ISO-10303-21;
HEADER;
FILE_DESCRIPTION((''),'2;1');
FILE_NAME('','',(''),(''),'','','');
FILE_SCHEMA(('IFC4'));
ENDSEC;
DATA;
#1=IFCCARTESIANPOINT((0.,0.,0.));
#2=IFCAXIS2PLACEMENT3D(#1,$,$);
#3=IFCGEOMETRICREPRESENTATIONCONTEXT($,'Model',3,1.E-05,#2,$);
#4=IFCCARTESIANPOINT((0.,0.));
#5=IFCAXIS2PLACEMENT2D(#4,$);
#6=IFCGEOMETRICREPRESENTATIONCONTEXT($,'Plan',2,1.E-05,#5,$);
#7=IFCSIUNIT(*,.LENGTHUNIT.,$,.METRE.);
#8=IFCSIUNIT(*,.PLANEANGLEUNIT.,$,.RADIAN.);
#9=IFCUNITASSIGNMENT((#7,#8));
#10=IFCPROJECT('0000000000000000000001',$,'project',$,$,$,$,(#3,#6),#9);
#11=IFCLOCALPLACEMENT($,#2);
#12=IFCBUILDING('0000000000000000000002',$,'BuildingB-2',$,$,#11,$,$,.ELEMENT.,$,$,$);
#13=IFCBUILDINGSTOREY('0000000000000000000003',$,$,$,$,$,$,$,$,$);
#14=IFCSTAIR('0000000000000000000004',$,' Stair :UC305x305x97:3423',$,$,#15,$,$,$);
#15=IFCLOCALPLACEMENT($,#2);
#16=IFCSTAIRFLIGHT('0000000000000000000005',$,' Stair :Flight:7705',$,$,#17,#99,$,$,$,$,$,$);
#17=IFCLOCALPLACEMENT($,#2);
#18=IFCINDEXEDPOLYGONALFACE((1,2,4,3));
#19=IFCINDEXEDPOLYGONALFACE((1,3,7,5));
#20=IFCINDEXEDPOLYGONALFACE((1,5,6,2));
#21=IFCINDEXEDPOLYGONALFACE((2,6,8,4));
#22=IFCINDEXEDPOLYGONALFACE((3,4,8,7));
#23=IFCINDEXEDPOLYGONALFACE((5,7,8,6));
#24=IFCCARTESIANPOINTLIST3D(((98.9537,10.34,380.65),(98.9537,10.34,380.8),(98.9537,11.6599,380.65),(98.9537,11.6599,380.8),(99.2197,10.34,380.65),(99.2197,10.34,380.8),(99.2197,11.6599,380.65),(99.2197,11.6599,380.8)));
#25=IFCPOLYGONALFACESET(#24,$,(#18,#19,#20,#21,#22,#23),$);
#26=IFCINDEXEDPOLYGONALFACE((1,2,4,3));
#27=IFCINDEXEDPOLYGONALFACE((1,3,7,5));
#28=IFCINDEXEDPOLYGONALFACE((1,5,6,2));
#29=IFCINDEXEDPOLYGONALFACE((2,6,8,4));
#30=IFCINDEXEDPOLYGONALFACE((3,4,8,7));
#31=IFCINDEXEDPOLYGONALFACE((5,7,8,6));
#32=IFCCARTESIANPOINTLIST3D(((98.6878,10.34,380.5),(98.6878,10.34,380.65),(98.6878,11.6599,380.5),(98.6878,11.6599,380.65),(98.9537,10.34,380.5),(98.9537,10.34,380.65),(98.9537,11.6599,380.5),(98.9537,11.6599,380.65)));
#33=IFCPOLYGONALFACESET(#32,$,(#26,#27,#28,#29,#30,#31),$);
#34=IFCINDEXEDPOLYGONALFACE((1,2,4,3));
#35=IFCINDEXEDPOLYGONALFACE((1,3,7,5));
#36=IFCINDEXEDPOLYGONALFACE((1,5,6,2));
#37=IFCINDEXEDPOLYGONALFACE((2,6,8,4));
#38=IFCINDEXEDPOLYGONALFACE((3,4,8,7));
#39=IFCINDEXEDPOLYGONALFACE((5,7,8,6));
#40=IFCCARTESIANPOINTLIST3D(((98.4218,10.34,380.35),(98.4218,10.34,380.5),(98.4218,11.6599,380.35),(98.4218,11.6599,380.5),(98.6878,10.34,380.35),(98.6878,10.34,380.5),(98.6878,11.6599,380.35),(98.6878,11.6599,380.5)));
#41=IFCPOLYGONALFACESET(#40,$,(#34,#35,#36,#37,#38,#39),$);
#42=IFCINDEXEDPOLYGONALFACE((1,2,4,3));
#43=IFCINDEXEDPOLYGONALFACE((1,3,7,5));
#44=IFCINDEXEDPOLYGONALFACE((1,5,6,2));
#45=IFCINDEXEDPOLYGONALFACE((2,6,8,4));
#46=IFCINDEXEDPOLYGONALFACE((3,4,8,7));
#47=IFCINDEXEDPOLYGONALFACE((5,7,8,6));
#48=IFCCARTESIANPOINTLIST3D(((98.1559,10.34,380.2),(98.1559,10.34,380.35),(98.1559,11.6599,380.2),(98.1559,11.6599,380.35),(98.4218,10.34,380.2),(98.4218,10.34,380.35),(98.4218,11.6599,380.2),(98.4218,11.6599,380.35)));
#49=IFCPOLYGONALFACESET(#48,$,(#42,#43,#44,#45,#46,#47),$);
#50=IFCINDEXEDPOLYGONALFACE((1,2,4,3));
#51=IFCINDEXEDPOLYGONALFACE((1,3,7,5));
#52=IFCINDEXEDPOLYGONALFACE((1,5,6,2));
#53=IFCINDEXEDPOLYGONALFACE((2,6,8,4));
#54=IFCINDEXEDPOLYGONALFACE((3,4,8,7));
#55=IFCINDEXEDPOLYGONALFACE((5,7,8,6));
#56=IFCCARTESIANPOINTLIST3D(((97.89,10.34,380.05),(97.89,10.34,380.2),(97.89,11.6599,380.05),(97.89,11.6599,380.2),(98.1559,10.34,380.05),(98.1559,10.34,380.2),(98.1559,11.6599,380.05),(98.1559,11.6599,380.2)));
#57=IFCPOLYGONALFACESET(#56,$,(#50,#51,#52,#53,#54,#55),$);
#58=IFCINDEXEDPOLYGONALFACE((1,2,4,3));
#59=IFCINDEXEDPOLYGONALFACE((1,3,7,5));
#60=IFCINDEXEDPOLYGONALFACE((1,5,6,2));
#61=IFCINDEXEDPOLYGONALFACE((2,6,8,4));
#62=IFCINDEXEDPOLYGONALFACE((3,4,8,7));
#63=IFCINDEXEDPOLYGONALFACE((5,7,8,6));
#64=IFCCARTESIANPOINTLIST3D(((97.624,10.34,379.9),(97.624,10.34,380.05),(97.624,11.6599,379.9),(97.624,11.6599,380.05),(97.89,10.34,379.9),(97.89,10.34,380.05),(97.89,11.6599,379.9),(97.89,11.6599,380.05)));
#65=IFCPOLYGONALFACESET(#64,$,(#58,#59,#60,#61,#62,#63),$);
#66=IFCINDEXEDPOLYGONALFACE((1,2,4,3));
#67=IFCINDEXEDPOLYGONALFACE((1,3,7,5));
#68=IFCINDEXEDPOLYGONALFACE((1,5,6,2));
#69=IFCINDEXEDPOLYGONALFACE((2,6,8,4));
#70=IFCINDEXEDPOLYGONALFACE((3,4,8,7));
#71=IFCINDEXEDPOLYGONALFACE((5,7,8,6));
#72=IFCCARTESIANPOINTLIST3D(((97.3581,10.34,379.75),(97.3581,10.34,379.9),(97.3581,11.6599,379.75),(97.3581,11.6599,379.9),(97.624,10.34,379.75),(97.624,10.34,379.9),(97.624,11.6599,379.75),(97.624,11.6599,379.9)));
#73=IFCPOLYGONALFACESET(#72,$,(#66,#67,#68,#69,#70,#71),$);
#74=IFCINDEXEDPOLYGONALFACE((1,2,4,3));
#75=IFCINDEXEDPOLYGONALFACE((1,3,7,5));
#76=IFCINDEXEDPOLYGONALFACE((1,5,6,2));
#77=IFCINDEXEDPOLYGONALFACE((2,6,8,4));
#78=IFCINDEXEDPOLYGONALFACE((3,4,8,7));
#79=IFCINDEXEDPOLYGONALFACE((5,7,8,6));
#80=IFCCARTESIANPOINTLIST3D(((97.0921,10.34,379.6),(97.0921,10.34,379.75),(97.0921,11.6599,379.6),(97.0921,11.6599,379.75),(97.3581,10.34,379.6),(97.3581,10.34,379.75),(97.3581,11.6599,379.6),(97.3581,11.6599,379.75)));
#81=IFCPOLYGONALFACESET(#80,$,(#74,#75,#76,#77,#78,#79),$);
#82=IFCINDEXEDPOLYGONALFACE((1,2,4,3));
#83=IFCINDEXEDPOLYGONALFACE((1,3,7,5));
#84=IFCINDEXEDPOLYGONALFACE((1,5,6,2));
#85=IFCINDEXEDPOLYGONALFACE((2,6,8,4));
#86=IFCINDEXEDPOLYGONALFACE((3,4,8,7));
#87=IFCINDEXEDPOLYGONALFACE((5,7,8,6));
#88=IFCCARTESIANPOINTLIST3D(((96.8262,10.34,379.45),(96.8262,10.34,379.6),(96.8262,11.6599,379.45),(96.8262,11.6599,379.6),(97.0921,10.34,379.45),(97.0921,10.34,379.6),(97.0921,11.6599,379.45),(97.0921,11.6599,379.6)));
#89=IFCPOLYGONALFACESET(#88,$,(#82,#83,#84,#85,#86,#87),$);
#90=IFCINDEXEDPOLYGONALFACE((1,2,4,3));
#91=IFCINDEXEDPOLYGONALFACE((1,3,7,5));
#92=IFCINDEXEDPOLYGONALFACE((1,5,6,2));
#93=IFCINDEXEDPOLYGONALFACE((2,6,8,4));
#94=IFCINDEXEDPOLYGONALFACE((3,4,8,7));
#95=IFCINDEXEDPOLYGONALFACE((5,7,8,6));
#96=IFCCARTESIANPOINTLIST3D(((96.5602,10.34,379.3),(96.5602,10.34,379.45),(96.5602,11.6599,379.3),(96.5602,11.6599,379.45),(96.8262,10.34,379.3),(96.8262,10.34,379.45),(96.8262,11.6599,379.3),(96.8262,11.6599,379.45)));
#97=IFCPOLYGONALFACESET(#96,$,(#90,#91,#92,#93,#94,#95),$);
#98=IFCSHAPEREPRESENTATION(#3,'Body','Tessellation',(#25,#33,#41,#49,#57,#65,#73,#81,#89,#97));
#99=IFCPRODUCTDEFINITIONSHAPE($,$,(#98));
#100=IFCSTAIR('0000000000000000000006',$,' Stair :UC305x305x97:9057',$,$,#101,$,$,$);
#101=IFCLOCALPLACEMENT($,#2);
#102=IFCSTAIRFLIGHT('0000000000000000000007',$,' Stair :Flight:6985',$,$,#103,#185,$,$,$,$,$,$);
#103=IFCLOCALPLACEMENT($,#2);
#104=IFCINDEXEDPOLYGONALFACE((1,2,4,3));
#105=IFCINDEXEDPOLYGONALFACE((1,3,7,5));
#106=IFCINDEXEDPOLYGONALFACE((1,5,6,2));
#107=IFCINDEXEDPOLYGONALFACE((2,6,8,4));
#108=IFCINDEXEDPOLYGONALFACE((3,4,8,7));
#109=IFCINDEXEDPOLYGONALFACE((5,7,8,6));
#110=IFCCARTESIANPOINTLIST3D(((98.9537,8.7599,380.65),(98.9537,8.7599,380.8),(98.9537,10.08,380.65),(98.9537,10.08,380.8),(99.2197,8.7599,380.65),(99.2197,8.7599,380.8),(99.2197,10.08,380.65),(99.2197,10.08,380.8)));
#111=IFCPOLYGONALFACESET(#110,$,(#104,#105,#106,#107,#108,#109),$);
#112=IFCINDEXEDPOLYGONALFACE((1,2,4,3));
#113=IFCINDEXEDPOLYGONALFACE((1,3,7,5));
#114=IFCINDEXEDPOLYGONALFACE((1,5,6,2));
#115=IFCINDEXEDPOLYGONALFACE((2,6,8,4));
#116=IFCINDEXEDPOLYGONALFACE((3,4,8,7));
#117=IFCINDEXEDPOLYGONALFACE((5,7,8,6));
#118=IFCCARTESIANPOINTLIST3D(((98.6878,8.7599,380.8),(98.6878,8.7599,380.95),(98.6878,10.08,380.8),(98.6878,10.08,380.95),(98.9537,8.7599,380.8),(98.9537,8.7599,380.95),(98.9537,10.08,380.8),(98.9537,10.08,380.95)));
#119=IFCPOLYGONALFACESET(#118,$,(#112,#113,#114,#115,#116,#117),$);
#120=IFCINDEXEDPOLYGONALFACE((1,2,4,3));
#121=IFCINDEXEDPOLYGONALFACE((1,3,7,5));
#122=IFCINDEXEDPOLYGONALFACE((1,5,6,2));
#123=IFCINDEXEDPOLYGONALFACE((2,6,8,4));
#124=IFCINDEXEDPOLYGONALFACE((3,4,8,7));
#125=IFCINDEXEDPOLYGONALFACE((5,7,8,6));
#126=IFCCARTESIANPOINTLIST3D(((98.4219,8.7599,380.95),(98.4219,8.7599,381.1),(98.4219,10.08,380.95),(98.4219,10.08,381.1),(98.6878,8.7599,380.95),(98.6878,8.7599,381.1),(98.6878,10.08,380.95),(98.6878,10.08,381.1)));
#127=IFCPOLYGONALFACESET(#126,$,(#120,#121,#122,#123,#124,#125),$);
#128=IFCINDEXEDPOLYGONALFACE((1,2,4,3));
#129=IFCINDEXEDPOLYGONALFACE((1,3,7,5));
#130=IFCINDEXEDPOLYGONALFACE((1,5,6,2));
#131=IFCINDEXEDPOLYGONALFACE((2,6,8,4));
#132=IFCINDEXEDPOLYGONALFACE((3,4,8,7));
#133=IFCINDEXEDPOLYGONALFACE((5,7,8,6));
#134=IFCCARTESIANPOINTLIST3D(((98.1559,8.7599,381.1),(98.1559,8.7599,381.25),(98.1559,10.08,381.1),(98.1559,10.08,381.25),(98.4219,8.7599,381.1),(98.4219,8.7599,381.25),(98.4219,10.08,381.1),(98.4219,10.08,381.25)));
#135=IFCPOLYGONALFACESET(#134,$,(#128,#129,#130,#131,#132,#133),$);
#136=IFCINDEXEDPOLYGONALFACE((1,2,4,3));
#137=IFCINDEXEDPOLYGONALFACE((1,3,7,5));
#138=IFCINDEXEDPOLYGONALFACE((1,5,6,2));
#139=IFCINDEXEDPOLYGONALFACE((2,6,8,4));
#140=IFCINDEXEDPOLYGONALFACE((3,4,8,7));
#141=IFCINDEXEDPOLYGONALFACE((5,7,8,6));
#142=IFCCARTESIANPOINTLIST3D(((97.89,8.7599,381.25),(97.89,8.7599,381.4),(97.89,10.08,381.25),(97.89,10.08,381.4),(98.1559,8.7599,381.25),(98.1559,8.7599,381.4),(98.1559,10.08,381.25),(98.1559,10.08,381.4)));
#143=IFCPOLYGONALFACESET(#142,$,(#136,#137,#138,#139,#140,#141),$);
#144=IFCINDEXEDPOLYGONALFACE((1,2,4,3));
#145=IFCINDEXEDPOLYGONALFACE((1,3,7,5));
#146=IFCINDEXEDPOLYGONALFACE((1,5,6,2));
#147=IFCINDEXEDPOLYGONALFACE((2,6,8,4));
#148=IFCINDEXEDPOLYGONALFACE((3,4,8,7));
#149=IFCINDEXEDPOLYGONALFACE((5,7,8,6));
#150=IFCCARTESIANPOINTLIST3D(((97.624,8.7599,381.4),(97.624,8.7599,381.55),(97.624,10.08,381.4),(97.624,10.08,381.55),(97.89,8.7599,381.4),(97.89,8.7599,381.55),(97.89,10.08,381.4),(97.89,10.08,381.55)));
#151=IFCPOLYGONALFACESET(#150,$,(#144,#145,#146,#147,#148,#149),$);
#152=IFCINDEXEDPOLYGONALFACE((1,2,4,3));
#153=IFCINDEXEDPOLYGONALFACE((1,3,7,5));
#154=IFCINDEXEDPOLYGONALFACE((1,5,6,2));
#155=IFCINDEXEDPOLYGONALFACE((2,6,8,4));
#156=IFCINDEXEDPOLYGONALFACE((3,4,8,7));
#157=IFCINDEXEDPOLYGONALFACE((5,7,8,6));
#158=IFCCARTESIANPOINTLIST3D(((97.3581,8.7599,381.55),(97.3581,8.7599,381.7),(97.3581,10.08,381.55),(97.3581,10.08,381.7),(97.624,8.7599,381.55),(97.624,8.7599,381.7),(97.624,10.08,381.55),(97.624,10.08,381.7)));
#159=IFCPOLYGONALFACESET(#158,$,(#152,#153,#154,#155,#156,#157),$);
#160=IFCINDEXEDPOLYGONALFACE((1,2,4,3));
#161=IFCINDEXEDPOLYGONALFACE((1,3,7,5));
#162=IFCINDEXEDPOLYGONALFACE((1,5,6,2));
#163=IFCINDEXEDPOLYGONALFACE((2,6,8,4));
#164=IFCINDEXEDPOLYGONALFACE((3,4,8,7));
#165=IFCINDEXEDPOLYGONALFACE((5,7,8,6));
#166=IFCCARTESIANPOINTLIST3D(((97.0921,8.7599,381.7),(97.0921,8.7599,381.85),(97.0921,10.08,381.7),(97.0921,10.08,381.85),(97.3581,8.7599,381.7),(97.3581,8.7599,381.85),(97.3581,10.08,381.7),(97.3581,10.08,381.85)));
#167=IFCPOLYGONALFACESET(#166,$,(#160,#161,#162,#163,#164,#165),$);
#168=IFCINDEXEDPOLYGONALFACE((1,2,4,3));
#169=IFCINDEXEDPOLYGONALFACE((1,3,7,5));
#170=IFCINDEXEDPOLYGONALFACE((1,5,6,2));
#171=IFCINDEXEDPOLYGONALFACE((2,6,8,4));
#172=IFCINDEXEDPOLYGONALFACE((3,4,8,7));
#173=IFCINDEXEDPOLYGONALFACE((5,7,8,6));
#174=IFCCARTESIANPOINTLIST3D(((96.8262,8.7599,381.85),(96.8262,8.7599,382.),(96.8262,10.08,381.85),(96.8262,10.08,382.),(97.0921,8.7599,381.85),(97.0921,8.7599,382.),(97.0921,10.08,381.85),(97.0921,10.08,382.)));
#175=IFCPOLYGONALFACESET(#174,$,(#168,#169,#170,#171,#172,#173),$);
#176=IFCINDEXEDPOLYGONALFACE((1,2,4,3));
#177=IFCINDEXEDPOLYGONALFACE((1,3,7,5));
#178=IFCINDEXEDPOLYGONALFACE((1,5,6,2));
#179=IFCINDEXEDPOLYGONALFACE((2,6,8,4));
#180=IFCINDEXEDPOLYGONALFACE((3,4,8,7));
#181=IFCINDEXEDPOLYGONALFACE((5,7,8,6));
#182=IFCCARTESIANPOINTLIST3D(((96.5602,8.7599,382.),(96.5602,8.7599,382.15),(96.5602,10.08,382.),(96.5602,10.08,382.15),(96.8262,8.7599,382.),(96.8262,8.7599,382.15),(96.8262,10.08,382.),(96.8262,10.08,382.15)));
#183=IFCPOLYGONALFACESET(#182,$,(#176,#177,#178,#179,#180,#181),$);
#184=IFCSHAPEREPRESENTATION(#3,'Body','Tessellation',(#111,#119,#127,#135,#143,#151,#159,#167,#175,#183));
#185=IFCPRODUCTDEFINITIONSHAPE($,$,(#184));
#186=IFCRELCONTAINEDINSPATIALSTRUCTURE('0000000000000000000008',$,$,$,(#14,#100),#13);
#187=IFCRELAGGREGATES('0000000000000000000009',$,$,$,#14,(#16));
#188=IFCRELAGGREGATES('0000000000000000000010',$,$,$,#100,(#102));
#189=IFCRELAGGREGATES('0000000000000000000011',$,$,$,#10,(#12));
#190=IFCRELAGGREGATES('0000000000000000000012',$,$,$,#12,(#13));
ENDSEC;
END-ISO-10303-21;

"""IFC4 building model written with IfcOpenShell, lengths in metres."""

from ifc_helpers import new_model, si_unit, frame, origin, origin_2d, place, context, project, spatial, polyline, outline, extrude, element, aggregate, save


model = new_model("IFC4")

# Units and contexts
model_context = context("Model", 3, precision=1e-05, world=origin())
plan_context = context("Plan", 2, precision=1e-05, world=origin_2d())
ifc_project = project(units=[si_unit("LENGTHUNIT", "METRE"), si_unit("PLANEANGLEUNIT", "RADIAN")], contexts=[model_context, plan_context])

# Building, storey
building_placement = place(None, origin())
building = spatial("IfcBuilding", under=ifc_project, at=building_placement, Name="BuildingB-2", CompositionType="ELEMENT")
storey = spatial("IfcBuildingStorey", under=building)

# Stairs, stair flights
stair_1 = element("IfcStair", 1, inside=storey, Name=" Stair :UC305x305x97:3423")
stair_flight_1 = element("IfcStairFlight", 2, Name=" Stair :Flight:7705", context=model_context, shape_type="SweptSolid", body=[
    extrude(outline(polyline([(98.9537, 11.6599, 380.8), (98.9537, 10.34, 380.8), (99.2197, 10.34, 380.8), (99.2197, 11.6599, 380.8), (98.9537, 11.6599, 380.8)])), origin(), (0.0, 0.0, -1.0), 0.15),
    extrude(outline(polyline([(98.6878, 11.6599, 380.8), (98.6878, 10.34, 380.8), (98.9537, 10.34, 380.8), (98.9537, 11.6599, 380.8), (98.6878, 11.6599, 380.8)])), frame((0.0, 0.0, -0.15)), (0.0, 0.0, -1.0), 0.15),
    extrude(outline(polyline([(98.4218, 11.6599, 380.8), (98.4218, 10.34, 380.8), (98.6878, 10.34, 380.8), (98.6878, 11.6599, 380.8), (98.4218, 11.6599, 380.8)])), frame((0.0, 0.0, -0.3)), (0.0, 0.0, -1.0), 0.15),
    extrude(outline(polyline([(98.1559, 11.6599, 380.8), (98.1559, 10.34, 380.8), (98.4218, 10.34, 380.8), (98.4218, 11.6599, 380.8), (98.1559, 11.6599, 380.8)])), frame((0.0, 0.0, -0.45)), (0.0, 0.0, -1.0), 0.15),
    extrude(outline(polyline([(97.89, 11.6599, 380.8), (97.89, 10.34, 380.8), (98.1559, 10.34, 380.8), (98.1559, 11.6599, 380.8), (97.89, 11.6599, 380.8)])), frame((0.0, 0.0, -0.6)), (0.0, 0.0, -1.0), 0.15),
    extrude(outline(polyline([(97.624, 11.6599, 380.8), (97.624, 10.34, 380.8), (97.89, 10.34, 380.8), (97.89, 11.6599, 380.8), (97.624, 11.6599, 380.8)])), frame((0.0, 0.0, -0.75)), (0.0, 0.0, -1.0), 0.15),
    extrude(outline(polyline([(97.3581, 11.6599, 380.8), (97.3581, 10.34, 380.8), (97.624, 10.34, 380.8), (97.624, 11.6599, 380.8), (97.3581, 11.6599, 380.8)])), frame((0.0, 0.0, -0.9)), (0.0, 0.0, -1.0), 0.15),
    extrude(outline(polyline([(97.0921, 11.6599, 380.8), (97.0921, 10.34, 380.8), (97.3581, 10.34, 380.8), (97.3581, 11.6599, 380.8), (97.0921, 11.6599, 380.8)])), frame((0.0, 0.0, -1.05)), (0.0, 0.0, -1.0), 0.15),
    extrude(outline(polyline([(96.8262, 11.6599, 380.8), (96.8262, 10.34, 380.8), (97.0921, 10.34, 380.8), (97.0921, 11.6599, 380.8), (96.8262, 11.6599, 380.8)])), frame((0.0, 0.0, -1.2)), (0.0, 0.0, -1.0), 0.15),
    extrude(outline(polyline([(96.5602, 11.6599, 380.8), (96.5602, 10.34, 380.8), (96.8262, 10.34, 380.8), (96.8262, 11.6599, 380.8), (96.5602, 11.6599, 380.8)])), frame((0.0, 0.0, -1.35)), (0.0, 0.0, -1.0), 0.15),
])
aggregate(stair_1, [stair_flight_1])
stair_2 = element("IfcStair", 3, inside=storey, Name=" Stair :UC305x305x97:9057")
stair_flight_2 = element("IfcStairFlight", 4, Name=" Stair :Flight:6985", context=model_context, shape_type="SweptSolid", body=[
    extrude(outline(polyline([(98.9537, 8.7599, 380.8), (98.9537, 10.08, 380.8), (99.2197, 10.08, 380.8), (99.2197, 8.7599, 380.8), (98.9537, 8.7599, 380.8)])), origin(), (0.0, 0.0, -1.0), 0.15),
    extrude(outline(polyline([(98.6878, 8.7599, 380.8), (98.6878, 10.08, 380.8), (98.9537, 10.08, 380.8), (98.9537, 8.7599, 380.8), (98.6878, 8.7599, 380.8)])), frame((0.0, 0.0, 0.15)), (0.0, 0.0, -1.0), 0.15),
    extrude(outline(polyline([(98.4219, 8.7599, 380.8), (98.4219, 10.08, 380.8), (98.6878, 10.08, 380.8), (98.6878, 8.7599, 380.8), (98.4219, 8.7599, 380.8)])), frame((0.0, 0.0, 0.3)), (0.0, 0.0, -1.0), 0.15),
    extrude(outline(polyline([(98.1559, 8.7599, 380.8), (98.1559, 10.08, 380.8), (98.4219, 10.08, 380.8), (98.4219, 8.7599, 380.8), (98.1559, 8.7599, 380.8)])), frame((0.0, 0.0, 0.45)), (0.0, 0.0, -1.0), 0.15),
    extrude(outline(polyline([(97.89, 8.7599, 380.8), (97.89, 10.08, 380.8), (98.1559, 10.08, 380.8), (98.1559, 8.7599, 380.8), (97.89, 8.7599, 380.8)])), frame((0.0, 0.0, 0.6)), (0.0, 0.0, -1.0), 0.15),
    extrude(outline(polyline([(97.624, 8.7599, 380.8), (97.624, 10.08, 380.8), (97.89, 10.08, 380.8), (97.89, 8.7599, 380.8), (97.624, 8.7599, 380.8)])), frame((0.0, 0.0, 0.75)), (0.0, 0.0, -1.0), 0.15),
    extrude(outline(polyline([(97.3581, 8.7599, 380.8), (97.3581, 10.08, 380.8), (97.624, 10.08, 380.8), (97.624, 8.7599, 380.8), (97.3581, 8.7599, 380.8)])), frame((0.0, 0.0, 0.9)), (0.0, 0.0, -1.0), 0.15),
    extrude(outline(polyline([(97.0921, 8.7599, 380.8), (97.0921, 10.08, 380.8), (97.3581, 10.08, 380.8), (97.3581, 8.7599, 380.8), (97.0921, 8.7599, 380.8)])), frame((0.0, 0.0, 1.05)), (0.0, 0.0, -1.0), 0.15),
    extrude(outline(polyline([(96.8262, 8.7599, 380.8), (96.8262, 10.08, 380.8), (97.0921, 10.08, 380.8), (97.0921, 8.7599, 380.8), (96.8262, 8.7599, 380.8)])), frame((0.0, 0.0, 1.2)), (0.0, 0.0, -1.0), 0.15),
    extrude(outline(polyline([(96.5602, 8.7599, 380.8), (96.5602, 10.08, 380.8), (96.8262, 10.08, 380.8), (96.8262, 8.7599, 380.8), (96.5602, 8.7599, 380.8)])), frame((0.0, 0.0, 1.35)), (0.0, 0.0, -1.0), 0.15),
])
aggregate(stair_2, [stair_flight_2])

save(model, "model.ifc")
